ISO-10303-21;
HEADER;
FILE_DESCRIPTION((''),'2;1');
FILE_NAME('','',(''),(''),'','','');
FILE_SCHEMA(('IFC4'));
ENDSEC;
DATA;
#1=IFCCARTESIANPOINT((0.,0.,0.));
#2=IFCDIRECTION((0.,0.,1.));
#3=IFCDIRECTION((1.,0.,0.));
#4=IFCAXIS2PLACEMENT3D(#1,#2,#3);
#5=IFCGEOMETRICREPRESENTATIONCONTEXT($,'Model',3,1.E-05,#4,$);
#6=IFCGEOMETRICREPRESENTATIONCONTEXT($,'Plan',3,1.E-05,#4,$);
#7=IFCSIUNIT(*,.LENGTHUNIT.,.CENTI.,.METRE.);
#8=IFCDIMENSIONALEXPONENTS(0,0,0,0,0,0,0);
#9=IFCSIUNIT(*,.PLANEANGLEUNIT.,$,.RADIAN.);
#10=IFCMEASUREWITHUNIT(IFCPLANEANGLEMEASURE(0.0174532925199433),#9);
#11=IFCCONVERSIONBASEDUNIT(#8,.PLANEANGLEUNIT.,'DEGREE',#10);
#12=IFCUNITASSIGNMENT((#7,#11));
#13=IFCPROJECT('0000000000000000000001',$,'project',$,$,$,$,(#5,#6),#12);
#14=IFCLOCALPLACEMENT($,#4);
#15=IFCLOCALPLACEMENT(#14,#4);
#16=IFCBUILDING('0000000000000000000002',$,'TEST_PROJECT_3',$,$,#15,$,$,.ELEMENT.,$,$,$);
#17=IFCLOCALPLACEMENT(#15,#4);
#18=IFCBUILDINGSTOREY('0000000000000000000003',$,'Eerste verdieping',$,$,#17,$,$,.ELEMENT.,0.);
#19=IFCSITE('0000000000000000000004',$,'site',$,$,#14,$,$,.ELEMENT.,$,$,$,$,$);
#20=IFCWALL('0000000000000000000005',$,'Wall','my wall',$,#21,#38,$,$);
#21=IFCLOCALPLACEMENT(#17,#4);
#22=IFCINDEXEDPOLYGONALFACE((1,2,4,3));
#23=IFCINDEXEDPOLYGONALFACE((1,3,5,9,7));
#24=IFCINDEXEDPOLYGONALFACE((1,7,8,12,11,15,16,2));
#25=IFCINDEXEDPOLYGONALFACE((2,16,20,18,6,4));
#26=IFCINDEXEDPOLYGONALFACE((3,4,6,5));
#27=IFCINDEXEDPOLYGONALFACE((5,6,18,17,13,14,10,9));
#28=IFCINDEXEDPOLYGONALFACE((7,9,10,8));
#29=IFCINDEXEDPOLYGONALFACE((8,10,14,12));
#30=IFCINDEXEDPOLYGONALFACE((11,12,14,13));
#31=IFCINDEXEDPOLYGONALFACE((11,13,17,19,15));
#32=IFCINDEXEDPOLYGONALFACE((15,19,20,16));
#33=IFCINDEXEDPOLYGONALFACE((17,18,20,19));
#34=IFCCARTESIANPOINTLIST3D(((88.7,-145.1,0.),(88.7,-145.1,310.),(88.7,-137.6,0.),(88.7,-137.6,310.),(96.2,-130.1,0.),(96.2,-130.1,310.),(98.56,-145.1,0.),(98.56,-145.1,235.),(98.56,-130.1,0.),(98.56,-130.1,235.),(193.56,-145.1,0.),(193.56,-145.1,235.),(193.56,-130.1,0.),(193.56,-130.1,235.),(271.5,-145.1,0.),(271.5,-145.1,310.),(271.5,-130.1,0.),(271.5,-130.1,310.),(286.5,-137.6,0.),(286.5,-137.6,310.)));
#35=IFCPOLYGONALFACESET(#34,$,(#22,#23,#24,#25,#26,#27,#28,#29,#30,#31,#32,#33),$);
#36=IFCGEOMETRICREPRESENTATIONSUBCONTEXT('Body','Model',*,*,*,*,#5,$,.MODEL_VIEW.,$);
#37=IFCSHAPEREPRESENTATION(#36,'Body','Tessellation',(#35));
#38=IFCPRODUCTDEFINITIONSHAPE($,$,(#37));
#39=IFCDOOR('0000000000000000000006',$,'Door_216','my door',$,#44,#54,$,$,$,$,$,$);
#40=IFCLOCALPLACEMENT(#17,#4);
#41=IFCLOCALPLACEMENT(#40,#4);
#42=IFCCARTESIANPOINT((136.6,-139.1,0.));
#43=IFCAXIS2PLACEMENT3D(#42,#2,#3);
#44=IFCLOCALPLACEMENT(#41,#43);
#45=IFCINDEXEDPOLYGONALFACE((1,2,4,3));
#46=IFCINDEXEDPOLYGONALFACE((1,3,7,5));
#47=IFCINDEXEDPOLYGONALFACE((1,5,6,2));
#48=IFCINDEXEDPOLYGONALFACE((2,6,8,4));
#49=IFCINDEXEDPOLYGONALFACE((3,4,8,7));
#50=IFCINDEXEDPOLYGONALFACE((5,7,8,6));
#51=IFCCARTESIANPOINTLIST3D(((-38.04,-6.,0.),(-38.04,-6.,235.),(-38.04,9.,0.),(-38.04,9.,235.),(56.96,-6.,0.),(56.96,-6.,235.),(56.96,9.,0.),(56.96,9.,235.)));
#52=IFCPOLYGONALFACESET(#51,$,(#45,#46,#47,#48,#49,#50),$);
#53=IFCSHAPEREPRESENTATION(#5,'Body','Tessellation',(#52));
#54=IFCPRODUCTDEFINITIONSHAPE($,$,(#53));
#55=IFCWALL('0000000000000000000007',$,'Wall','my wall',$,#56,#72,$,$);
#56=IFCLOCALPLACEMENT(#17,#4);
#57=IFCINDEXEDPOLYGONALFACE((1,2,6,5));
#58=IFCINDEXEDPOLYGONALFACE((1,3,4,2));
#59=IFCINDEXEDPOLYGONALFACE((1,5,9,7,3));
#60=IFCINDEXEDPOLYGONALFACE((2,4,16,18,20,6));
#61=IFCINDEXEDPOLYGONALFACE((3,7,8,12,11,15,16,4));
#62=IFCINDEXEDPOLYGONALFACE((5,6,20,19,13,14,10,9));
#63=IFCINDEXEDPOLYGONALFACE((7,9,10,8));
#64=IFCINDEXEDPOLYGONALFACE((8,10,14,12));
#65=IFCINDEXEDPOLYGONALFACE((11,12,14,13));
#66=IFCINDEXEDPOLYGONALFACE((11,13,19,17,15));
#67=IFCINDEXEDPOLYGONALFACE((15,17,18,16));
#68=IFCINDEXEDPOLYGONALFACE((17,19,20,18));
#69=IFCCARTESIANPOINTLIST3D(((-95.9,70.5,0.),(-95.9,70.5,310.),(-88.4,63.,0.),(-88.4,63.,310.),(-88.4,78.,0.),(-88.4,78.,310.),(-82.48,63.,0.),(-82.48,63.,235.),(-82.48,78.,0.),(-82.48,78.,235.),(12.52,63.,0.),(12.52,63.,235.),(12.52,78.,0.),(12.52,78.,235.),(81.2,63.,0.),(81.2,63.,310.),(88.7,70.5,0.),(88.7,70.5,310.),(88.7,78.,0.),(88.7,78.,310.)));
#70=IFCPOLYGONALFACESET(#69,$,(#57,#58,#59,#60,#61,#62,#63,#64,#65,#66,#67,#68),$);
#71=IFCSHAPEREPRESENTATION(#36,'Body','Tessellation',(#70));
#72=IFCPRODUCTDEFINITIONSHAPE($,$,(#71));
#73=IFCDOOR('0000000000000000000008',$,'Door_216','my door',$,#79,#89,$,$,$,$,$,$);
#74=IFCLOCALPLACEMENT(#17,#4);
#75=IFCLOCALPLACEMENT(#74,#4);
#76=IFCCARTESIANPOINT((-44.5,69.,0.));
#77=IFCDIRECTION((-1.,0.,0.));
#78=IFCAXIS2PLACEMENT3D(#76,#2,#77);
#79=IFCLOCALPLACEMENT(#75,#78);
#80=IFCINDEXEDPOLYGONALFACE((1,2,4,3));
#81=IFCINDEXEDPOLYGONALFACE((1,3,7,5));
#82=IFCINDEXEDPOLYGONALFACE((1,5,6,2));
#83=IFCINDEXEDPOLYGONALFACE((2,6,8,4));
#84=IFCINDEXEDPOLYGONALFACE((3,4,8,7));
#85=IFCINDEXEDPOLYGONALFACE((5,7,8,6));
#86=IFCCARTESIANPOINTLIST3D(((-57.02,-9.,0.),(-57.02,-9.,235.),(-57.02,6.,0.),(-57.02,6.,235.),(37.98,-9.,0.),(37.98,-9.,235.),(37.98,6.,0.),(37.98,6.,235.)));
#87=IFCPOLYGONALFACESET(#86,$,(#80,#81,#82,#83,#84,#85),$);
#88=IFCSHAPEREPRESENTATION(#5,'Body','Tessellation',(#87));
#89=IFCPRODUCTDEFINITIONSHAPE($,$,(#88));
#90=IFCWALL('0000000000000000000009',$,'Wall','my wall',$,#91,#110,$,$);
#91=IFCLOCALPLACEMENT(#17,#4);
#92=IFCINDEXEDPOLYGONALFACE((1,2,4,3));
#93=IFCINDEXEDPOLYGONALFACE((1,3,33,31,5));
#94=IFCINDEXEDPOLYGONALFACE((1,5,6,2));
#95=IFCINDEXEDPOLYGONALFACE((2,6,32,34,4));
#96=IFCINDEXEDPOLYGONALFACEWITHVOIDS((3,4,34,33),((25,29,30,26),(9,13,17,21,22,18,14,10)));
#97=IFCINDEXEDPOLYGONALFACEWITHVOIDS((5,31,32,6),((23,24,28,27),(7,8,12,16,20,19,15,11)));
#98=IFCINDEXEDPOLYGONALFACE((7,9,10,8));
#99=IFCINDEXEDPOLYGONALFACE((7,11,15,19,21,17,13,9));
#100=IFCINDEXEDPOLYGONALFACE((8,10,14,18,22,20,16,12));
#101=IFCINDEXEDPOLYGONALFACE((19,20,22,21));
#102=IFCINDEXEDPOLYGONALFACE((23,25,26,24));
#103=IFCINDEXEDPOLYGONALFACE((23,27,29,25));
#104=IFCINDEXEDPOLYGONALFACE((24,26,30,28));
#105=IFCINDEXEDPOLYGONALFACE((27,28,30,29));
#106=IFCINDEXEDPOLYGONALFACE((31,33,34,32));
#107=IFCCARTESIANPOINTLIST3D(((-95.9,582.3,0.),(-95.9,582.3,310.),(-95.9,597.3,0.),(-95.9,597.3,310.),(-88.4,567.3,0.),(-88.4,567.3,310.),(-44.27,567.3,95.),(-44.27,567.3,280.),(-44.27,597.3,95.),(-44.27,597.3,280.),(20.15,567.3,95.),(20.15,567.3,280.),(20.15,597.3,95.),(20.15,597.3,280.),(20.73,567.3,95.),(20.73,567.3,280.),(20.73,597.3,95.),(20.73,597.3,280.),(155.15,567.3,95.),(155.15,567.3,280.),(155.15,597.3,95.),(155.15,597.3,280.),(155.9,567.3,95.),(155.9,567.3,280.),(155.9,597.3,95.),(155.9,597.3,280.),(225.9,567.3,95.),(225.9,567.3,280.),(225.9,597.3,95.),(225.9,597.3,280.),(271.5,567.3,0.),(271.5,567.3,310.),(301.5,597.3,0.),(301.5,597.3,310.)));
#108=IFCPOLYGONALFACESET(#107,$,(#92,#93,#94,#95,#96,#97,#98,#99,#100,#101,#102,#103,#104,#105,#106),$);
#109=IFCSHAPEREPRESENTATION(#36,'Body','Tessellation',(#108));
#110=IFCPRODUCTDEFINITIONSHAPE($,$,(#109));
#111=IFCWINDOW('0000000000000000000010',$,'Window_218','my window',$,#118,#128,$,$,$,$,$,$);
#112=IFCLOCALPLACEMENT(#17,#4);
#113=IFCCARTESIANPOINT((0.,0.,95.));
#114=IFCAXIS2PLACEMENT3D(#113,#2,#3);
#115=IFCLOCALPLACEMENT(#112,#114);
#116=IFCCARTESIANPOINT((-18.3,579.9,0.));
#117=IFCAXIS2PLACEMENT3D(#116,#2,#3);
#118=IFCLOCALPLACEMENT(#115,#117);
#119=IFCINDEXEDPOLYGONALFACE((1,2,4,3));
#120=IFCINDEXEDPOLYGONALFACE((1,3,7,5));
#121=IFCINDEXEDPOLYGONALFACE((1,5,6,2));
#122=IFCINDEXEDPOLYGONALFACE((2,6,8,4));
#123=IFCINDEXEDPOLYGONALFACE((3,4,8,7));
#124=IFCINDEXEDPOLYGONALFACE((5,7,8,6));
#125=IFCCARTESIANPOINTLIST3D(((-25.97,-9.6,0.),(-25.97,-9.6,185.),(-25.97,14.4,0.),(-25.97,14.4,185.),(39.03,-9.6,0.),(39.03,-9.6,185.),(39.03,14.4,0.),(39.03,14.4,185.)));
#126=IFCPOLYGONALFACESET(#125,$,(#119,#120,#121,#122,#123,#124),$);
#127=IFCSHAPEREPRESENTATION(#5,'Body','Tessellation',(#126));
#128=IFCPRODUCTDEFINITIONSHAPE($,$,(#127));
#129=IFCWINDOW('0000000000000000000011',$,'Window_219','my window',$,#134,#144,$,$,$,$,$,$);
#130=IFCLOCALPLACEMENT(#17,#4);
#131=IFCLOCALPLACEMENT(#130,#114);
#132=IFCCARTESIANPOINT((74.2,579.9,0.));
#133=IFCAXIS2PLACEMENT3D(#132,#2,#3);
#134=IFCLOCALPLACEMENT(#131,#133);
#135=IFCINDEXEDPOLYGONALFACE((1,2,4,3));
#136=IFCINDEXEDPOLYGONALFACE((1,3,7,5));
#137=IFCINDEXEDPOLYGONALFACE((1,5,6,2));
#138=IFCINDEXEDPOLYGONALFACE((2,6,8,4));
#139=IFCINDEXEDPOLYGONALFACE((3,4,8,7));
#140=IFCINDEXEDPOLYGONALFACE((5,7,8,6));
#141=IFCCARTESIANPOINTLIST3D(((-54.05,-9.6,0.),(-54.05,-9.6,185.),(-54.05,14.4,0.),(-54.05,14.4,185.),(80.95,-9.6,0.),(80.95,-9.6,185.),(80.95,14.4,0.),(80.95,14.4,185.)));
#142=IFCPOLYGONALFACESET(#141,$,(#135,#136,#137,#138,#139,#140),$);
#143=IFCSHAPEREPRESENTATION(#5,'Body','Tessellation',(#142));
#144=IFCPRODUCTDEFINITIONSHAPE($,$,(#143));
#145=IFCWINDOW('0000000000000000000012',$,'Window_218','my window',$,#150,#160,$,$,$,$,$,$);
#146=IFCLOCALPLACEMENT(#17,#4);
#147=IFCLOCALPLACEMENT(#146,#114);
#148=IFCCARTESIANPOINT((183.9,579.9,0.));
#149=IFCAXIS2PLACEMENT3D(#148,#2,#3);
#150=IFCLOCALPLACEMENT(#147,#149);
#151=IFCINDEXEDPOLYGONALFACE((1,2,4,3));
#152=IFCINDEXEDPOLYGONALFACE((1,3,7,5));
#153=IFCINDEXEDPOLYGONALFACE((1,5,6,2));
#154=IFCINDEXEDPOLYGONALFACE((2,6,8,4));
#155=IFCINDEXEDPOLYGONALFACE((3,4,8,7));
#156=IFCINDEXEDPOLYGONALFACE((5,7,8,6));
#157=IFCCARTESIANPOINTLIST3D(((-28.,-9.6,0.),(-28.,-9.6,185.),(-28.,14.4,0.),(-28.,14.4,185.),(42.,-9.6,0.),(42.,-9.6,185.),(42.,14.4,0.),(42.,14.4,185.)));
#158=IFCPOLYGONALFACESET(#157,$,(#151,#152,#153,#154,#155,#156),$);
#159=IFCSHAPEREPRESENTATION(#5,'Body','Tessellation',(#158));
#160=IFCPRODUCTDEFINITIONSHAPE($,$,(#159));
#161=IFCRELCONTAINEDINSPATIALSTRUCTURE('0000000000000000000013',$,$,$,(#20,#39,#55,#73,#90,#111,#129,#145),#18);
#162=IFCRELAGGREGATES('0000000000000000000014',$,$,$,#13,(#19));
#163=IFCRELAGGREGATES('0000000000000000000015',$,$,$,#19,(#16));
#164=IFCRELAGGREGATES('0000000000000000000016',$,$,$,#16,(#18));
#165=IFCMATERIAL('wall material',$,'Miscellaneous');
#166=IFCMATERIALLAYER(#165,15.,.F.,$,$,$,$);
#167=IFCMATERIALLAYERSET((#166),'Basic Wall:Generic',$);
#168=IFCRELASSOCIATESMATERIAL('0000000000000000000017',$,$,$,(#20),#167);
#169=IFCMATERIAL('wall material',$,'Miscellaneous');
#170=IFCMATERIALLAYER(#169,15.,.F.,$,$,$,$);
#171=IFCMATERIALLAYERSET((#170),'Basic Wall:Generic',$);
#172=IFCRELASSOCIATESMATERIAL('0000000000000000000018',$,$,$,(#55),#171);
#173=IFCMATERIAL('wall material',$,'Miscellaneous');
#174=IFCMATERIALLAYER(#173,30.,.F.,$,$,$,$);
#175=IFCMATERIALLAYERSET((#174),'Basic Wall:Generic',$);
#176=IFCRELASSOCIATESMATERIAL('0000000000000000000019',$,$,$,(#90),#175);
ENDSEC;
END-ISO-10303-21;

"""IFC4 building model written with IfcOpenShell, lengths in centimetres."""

from ifc_helpers import new_model, entity, si_unit, converted_unit, frame, origin_with_axes, place, context, subcontext, project, spatial, polyline, outline, extrude, material, layer, layer_set, layer_usage, element, fill, save


model = new_model("IFC4")

# Units and contexts
model_context = context("Model", 3, precision=1e-05, world=origin_with_axes())
plan_context = context("Plan", 3, precision=1e-05, world=origin_with_axes())
body_context = subcontext(model_context, "Body", "Model", "MODEL_VIEW")
ifc_project = project(units=[si_unit("LENGTHUNIT", "METRE", prefix="CENTI"), converted_unit("PLANEANGLEUNIT", "DEGREE", entity("IfcPlaneAngleMeasure", 0.0174532925199433), si_unit("PLANEANGLEUNIT", "RADIAN"), dimensions=[0, 0, 0, 0, 0, 0, 0])], contexts=[model_context, plan_context])

# Site, building, storey
site_placement = place(None, origin_with_axes())
site = spatial("IfcSite", under=ifc_project, at=site_placement, Name="site", CompositionType="ELEMENT")
building_placement = place(site_placement, origin_with_axes())
building = spatial("IfcBuilding", under=site, at=building_placement, Name="TEST_PROJECT_3", CompositionType="ELEMENT")
storey_placement = place(building_placement, origin_with_axes())
storey = spatial("IfcBuildingStorey", under=building, at=storey_placement, Name="Eerste verdieping", CompositionType="ELEMENT", Elevation=0.0)

# Wall, opening, door
ifc_material_1 = material(Name="wall material", Category="Miscellaneous")
ifc_layer_1 = layer(ifc_material_1, 15.0, ventilated=False)
ifc_layer_set_1 = layer_set([ifc_layer_1], Name="Basic Wall:Generic")
ifc_layer_usage_1 = layer_usage(ifc_layer_set_1, "AXIS3", "NEGATIVE", 0.0)
wall_1_placement = place(storey_placement, origin_with_axes())
wall_1 = element("IfcWall", 1, at=wall_1_placement, inside=storey, material=ifc_layer_usage_1, Name="Wall", Description="my wall", context=body_context, shape_type="SweptSolid", body=[
    extrude(outline(polyline([(88.7, -145.1, 0.0), (88.7, -137.6, 0.0), (96.2, -130.1, 0.0), (271.5, -130.1, 0.0), (286.5, -137.6, 0.0), (271.5, -145.1, 0.0), (88.7, -145.1, 0.0)])), origin_with_axes(), (0.0, 0.0, 1.0), 310.0),
])
placement_1 = place(storey_placement, origin_with_axes())
opening_1_placement = place(placement_1, origin_with_axes())
opening_1 = element("IfcOpeningElement", 2, at=opening_1_placement, cuts=wall_1, context=model_context, shape_type="SweptSolid", body=[
    extrude(outline(polyline([(98.56, -145.1, 0.0), (98.56, -130.1, 0.0), (193.56, -130.1, 0.0), (193.56, -145.1, 0.0), (98.56, -145.1, 0.0)])), origin_with_axes(), (0.0, 0.0, 1.0), 235.0),
])
door_1_placement = place(opening_1_placement, frame((136.6, -139.1, 0.0), z_axis=(0.0, 0.0, 1.0), x_axis=(1.0, 0.0, 0.0)))
door_1 = element("IfcDoor", 3, at=door_1_placement, inside=storey, Name="Door_216", Description="my door", context=model_context, shape_type="SweptSolid", body=[
    extrude(outline(polyline([(-38.04, -6.0), (-38.04, 9.0), (56.96, 9.0), (56.96, -6.0), (-38.04, -6.0)])), origin_with_axes(), (0.0, 0.0, 1.0), 235.0),
])
fill(opening_1, door_1)

# Wall, opening, door
ifc_material_2 = material(Name="wall material", Category="Miscellaneous")
ifc_layer_2 = layer(ifc_material_2, 15.0, ventilated=False)
ifc_layer_set_2 = layer_set([ifc_layer_2], Name="Basic Wall:Generic")
ifc_layer_usage_2 = layer_usage(ifc_layer_set_2, "AXIS3", "NEGATIVE", 0.0)
wall_2_placement = place(storey_placement, origin_with_axes())
wall_2 = element("IfcWall", 4, at=wall_2_placement, inside=storey, material=ifc_layer_usage_2, Name="Wall", Description="my wall", context=body_context, shape_type="SweptSolid", body=[
    extrude(outline(polyline([(-88.4, 63.0, 0.0), (-95.9, 70.5, 0.0), (-88.4, 78.0, 0.0), (88.7, 78.0, 0.0), (88.7, 70.5, 0.0), (81.2, 63.0, 0.0), (-88.4, 63.0, 0.0)])), origin_with_axes(), (0.0, 0.0, 1.0), 310.0),
])
placement_2 = place(storey_placement, origin_with_axes())
opening_2_placement = place(placement_2, origin_with_axes())
opening_2 = element("IfcOpeningElement", 5, at=opening_2_placement, cuts=wall_2, context=model_context, shape_type="SweptSolid", body=[
    extrude(outline(polyline([(-82.48, 63.0, 0.0), (-82.48, 78.0, 0.0), (12.52, 78.0, 0.0), (12.52, 63.0, 0.0), (-82.48, 63.0, 0.0)])), origin_with_axes(), (0.0, 0.0, 1.0), 235.0),
])
door_2_placement = place(opening_2_placement, frame((-44.5, 69.0, 0.0), z_axis=(0.0, 0.0, 1.0), x_axis=(-1.0, 0.0, 0.0)))
door_2 = element("IfcDoor", 6, at=door_2_placement, inside=storey, Name="Door_216", Description="my door", context=model_context, shape_type="SweptSolid", body=[
    extrude(outline(polyline([(37.98, 6.0), (37.98, -9.0), (-57.02, -9.0), (-57.02, 6.0), (37.98, 6.0)])), origin_with_axes(), (0.0, 0.0, 1.0), 235.0),
])
fill(opening_2, door_2)

# Wall, openings, windows
ifc_material_3 = material(Name="wall material", Category="Miscellaneous")
ifc_layer_3 = layer(ifc_material_3, 30.0, ventilated=False)
ifc_layer_set_3 = layer_set([ifc_layer_3], Name="Basic Wall:Generic")
ifc_layer_usage_3 = layer_usage(ifc_layer_set_3, "AXIS3", "NEGATIVE", 0.0)
wall_3_placement = place(storey_placement, origin_with_axes())
wall_3 = element("IfcWall", 7, at=wall_3_placement, inside=storey, material=ifc_layer_usage_3, Name="Wall", Description="my wall", context=body_context, shape_type="SweptSolid", body=[
    extrude(outline(polyline([(-88.4, 567.3, 0.0), (-95.9, 582.3, 0.0), (-95.9, 597.3, 0.0), (301.5, 597.3, 0.0), (271.5, 567.3, 0.0), (-88.4, 567.3, 0.0)])), origin_with_axes(), (0.0, 0.0, 1.0), 310.0),
])
placement_3 = place(storey_placement, origin_with_axes())
opening_3_placement = place(placement_3, frame((0.0, 0.0, 95.0), z_axis=(0.0, 0.0, 1.0), x_axis=(1.0, 0.0, 0.0)))
opening_3 = element("IfcOpeningElement", 8, at=opening_3_placement, cuts=wall_3, context=model_context, shape_type="SweptSolid", body=[
    extrude(outline(polyline([(-44.27, 567.3, 0.0), (-44.27, 597.3, 0.0), (20.73, 597.3, 0.0), (20.73, 567.3, 0.0), (-44.27, 567.3, 0.0)])), origin_with_axes(), (0.0, 0.0, 1.0), 185.0),
])
placement_4 = place(storey_placement, origin_with_axes())
opening_4_placement = place(placement_4, frame((0.0, 0.0, 95.0), z_axis=(0.0, 0.0, 1.0), x_axis=(1.0, 0.0, 0.0)))
opening_4 = element("IfcOpeningElement", 9, at=opening_4_placement, cuts=wall_3, context=model_context, shape_type="SweptSolid", body=[
    extrude(outline(polyline([(20.15, 567.3, 0.0), (20.15, 597.3, 0.0), (155.15, 597.3, 0.0), (155.15, 567.3, 0.0), (20.15, 567.3, 0.0)])), origin_with_axes(), (0.0, 0.0, 1.0), 185.0),
])
placement_5 = place(storey_placement, origin_with_axes())
opening_5_placement = place(placement_5, frame((0.0, 0.0, 95.0), z_axis=(0.0, 0.0, 1.0), x_axis=(1.0, 0.0, 0.0)))
opening_5 = element("IfcOpeningElement", 10, at=opening_5_placement, cuts=wall_3, context=model_context, shape_type="SweptSolid", body=[
    extrude(outline(polyline([(155.9, 567.3, 0.0), (155.9, 597.3, 0.0), (225.9, 597.3, 0.0), (225.9, 567.3, 0.0), (155.9, 567.3, 0.0)])), origin_with_axes(), (0.0, 0.0, 1.0), 185.0),
])
window_1_placement = place(opening_3_placement, frame((-18.3, 579.9, 0.0), z_axis=(0.0, 0.0, 1.0), x_axis=(1.0, 0.0, 0.0)))
window_1 = element("IfcWindow", 11, at=window_1_placement, inside=storey, Name="Window_218", Description="my window", context=model_context, shape_type="SweptSolid", body=[
    extrude(outline(polyline([(-25.97, -9.6), (-25.97, 14.4), (39.03, 14.4), (39.03, -9.6), (-25.97, -9.6)])), origin_with_axes(), (0.0, 0.0, 1.0), 185.0),
])
fill(opening_3, window_1)
window_2_placement = place(opening_4_placement, frame((74.2, 579.9, 0.0), z_axis=(0.0, 0.0, 1.0), x_axis=(1.0, 0.0, 0.0)))
window_2 = element("IfcWindow", 12, at=window_2_placement, inside=storey, Name="Window_219", Description="my window", context=model_context, shape_type="SweptSolid", body=[
    extrude(outline(polyline([(-54.05, -9.6), (-54.05, 14.4), (80.95, 14.4), (80.95, -9.6), (-54.05, -9.6)])), origin_with_axes(), (0.0, 0.0, 1.0), 185.0),
])
fill(opening_4, window_2)
window_3_placement = place(opening_5_placement, frame((183.9, 579.9, 0.0), z_axis=(0.0, 0.0, 1.0), x_axis=(1.0, 0.0, 0.0)))
window_3 = element("IfcWindow", 13, at=window_3_placement, inside=storey, Name="Window_218", Description="my window", context=model_context, shape_type="SweptSolid", body=[
    extrude(outline(polyline([(-28.0, -9.6), (-28.0, 14.4), (42.0, 14.4), (42.0, -9.6), (-28.0, -9.6)])), origin_with_axes(), (0.0, 0.0, 1.0), 185.0),
])
fill(opening_5, window_3)

save(model, "model.ifc")
